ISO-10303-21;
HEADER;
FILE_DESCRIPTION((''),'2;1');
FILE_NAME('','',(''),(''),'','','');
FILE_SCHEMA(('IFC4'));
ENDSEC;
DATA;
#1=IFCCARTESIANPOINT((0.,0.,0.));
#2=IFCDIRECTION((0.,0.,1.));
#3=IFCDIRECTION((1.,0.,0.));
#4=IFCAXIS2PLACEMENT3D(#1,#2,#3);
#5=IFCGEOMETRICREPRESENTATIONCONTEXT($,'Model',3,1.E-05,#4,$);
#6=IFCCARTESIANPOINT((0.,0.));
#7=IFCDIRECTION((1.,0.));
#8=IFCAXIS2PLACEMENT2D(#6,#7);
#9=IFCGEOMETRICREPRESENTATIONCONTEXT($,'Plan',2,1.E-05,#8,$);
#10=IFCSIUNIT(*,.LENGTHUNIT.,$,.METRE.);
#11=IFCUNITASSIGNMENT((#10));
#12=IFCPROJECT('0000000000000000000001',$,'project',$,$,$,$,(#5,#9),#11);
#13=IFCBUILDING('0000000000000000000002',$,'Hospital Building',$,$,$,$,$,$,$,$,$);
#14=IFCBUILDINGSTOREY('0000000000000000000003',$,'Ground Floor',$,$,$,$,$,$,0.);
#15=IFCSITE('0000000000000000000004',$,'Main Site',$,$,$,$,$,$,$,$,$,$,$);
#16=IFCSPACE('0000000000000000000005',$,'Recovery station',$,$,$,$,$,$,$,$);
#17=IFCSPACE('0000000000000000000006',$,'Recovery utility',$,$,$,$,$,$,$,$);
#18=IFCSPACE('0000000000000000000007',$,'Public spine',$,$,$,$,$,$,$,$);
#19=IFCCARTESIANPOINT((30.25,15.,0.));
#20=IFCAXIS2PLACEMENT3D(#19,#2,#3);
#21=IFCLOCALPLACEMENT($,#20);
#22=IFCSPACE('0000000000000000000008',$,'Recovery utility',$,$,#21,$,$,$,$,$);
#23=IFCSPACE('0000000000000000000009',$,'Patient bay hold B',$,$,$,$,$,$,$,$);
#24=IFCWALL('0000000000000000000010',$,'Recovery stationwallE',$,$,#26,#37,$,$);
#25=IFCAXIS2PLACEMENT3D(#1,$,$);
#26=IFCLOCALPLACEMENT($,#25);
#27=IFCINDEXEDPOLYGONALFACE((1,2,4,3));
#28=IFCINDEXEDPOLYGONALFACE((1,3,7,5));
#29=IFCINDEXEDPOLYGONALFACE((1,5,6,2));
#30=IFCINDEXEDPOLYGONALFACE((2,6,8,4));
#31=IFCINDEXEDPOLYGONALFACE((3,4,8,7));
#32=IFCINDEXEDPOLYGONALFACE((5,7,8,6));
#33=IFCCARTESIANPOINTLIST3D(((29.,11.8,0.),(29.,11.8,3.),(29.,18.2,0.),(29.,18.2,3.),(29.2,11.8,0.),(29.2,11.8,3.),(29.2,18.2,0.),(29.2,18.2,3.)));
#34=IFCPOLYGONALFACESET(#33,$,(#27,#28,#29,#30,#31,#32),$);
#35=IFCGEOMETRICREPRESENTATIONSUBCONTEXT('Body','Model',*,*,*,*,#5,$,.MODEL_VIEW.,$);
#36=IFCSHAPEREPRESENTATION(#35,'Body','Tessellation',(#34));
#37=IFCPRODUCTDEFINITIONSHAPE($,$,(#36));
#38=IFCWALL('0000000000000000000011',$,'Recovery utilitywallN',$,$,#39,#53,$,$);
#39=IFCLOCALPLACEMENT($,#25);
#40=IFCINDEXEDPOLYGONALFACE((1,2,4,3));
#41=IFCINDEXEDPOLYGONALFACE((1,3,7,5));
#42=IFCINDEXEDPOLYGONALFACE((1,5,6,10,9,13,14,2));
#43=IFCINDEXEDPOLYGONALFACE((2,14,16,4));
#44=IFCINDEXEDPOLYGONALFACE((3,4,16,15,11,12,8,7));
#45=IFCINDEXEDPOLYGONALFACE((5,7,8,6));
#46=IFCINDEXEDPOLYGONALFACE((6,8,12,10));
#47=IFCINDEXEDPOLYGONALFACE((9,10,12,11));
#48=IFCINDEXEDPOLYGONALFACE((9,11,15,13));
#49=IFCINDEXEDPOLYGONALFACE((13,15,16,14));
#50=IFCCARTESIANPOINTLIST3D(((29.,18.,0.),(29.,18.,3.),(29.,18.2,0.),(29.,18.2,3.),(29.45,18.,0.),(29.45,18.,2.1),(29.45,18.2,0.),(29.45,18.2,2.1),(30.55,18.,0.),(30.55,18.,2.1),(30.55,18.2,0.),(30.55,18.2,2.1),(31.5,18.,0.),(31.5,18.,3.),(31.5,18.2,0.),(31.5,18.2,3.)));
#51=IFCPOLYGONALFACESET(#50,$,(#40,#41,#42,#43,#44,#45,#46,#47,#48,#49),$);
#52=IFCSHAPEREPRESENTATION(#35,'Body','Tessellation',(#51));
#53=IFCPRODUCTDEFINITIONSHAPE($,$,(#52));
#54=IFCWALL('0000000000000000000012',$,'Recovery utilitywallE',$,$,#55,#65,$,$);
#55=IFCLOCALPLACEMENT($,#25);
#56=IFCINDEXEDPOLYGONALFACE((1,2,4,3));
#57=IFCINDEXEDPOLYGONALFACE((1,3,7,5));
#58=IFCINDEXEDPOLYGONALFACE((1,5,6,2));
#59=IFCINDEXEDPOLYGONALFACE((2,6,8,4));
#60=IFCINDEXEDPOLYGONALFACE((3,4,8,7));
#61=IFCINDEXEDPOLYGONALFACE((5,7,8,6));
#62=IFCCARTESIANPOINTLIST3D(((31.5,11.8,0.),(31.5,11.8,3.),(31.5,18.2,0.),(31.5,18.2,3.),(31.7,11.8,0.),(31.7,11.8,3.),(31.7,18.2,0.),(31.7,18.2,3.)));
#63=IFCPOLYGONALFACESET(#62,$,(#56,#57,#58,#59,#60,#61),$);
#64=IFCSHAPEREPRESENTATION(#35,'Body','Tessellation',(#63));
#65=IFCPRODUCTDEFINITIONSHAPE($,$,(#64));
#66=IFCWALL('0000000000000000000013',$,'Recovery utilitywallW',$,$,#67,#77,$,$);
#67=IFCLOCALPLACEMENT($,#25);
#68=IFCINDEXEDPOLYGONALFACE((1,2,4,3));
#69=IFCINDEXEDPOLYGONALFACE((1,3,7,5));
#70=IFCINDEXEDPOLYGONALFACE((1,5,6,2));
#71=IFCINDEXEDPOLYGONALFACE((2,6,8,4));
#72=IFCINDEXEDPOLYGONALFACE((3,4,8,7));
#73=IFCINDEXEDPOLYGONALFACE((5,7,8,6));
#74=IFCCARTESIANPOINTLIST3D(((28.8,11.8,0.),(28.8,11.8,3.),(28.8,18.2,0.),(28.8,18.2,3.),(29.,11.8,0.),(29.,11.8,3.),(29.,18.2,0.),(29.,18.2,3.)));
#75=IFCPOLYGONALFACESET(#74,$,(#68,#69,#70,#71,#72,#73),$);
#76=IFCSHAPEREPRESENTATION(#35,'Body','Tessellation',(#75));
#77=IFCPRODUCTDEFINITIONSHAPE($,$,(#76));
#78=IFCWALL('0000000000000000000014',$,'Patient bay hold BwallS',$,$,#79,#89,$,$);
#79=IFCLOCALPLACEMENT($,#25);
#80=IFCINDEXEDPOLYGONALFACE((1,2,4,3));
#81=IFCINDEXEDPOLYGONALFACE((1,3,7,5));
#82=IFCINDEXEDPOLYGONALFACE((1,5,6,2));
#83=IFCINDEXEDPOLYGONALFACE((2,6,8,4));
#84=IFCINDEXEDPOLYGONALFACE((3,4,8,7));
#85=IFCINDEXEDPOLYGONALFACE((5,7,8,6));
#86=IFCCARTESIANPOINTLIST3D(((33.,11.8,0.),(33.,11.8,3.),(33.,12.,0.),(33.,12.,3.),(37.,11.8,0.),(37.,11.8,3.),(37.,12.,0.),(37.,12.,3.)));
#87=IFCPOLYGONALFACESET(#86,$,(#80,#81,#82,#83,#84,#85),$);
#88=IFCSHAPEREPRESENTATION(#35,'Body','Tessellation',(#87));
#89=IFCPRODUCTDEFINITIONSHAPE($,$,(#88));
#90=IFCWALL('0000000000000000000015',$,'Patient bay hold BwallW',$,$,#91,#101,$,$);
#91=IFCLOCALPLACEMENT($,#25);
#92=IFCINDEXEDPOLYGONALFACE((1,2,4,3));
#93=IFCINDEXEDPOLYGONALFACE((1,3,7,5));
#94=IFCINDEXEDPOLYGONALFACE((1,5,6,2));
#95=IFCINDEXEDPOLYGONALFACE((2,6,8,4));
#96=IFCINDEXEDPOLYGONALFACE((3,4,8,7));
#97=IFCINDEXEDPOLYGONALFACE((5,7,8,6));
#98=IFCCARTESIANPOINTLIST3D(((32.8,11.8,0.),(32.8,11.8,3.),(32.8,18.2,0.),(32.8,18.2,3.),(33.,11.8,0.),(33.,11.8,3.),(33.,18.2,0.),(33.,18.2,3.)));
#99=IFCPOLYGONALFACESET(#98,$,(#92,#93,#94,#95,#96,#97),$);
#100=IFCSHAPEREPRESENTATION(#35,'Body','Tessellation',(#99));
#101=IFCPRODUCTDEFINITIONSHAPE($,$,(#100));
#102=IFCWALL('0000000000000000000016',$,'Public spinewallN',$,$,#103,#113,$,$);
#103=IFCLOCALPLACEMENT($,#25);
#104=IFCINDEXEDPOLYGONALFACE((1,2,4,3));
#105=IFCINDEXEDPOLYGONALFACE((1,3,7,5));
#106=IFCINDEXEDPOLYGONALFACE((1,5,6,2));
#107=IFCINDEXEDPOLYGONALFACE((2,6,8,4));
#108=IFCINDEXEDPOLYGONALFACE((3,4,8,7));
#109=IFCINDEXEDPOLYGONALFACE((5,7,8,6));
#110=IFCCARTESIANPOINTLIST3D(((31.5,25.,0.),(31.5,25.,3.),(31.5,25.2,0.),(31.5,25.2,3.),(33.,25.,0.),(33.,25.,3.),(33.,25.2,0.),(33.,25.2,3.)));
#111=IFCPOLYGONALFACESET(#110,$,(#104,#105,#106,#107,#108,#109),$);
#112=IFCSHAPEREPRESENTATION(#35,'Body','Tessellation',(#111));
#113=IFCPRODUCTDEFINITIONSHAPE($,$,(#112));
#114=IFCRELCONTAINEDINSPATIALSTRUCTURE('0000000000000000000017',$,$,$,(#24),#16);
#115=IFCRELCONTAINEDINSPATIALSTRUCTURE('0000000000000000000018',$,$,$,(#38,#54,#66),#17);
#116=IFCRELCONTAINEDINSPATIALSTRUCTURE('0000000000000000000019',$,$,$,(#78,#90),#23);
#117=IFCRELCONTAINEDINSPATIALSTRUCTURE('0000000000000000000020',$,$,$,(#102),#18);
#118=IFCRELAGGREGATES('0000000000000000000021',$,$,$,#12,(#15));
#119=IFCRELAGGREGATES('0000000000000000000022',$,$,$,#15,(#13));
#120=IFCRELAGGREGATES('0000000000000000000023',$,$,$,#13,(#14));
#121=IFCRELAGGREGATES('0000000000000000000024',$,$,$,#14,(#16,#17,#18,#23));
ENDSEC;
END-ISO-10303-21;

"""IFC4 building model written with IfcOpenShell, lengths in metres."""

from ifc_helpers import new_model, si_unit, frame, origin_with_axes, origin_2d_with_axis, place, context, subcontext, project, spatial, indexed_curve, outline, extrude, element, save


model = new_model("IFC4")

# Units and contexts
model_context = context("Model", 3, precision=1e-05, world=origin_with_axes())
plan_context = context("Plan", 2, precision=1e-05, world=origin_2d_with_axis())
body_context = subcontext(model_context, "Body", "Model", "MODEL_VIEW")
ifc_project = project(units=[si_unit("LENGTHUNIT", "METRE")], contexts=[model_context, plan_context])

# Site, building, storey
site = spatial("IfcSite", under=ifc_project, Name="Main Site")
building = spatial("IfcBuilding", under=site, Name="Hospital Building")
storey = spatial("IfcBuildingStorey", under=building, Name="Ground Floor", Elevation=0.0)

# Shared definitions
space_1 = spatial("IfcSpace", under=storey, Name="Recovery station")

# Shared definitions
space_2 = spatial("IfcSpace", under=storey, Name="Recovery utility")

# Shared definitions
space_3 = spatial("IfcSpace", under=storey, Name="Public spine")

# Walls
wall_1_placement = place(None, frame((29.2, 11.8, 0.0), z_axis=(0.0, 0.0, 1.0), x_axis=(0.0, 1.0, 0.0)))
element("IfcWall", 1, at=wall_1_placement, inside=space_1, Name="Recovery stationwallE", context=body_context, shape_type="SweptSolid", body=[
    extrude(outline(indexed_curve([(0.0, 0.0), (0.0, 0.2), (6.4, 0.2), (6.4, 0.0), (0.0, 0.0)], self_intersect=False)), origin_with_axes(), (0.0, 0.0, 1.0), 3.0),
])
wall_2_placement = place(None, frame((29.0, 18.0, 0.0), z_axis=(0.0, 0.0, 1.0), x_axis=(1.0, 0.0, 0.0)))
wall_2 = element("IfcWall", 2, at=wall_2_placement, inside=space_2, Name="Recovery utilitywallN", context=body_context, shape_type="SweptSolid", body=[
    extrude(outline(indexed_curve([(0.0, 0.0), (0.0, 0.2), (2.5, 0.2), (2.5, 0.0), (0.0, 0.0)], self_intersect=False)), origin_with_axes(), (0.0, 0.0, 1.0), 3.0),
])

# Shared definitions
space_4_placement = place(None, frame((30.25, 15.0, 0.0), z_axis=(0.0, 0.0, 1.0), x_axis=(1.0, 0.0, 0.0)))
space_4 = spatial("IfcSpace", at=space_4_placement, Name="Recovery utility")

# Opening
opening_1_placement = place(wall_2_placement, frame((0.45, -0.1, 0.0), z_axis=(0.0, 0.0, 1.0), x_axis=(1.0, 0.0, 0.0)))
element("IfcOpeningElement", 3, at=opening_1_placement, inside=space_4, cuts=wall_2, context=body_context, shape_type="SweptSolid", body=[
    extrude(outline(indexed_curve([(0.0, 0.0), (0.0, 0.4), (1.1, 0.4), (1.1, 0.0), (0.0, 0.0)], self_intersect=False)), origin_with_axes(), (0.0, 0.0, 1.0), 2.1),
])

# Walls
for number, where, z_axis, x_axis, name in (
    (4, (31.7, 11.8, 0.0), (0.0, 0.0, 1.0), (0.0, 1.0, 0.0), "Recovery utilitywallE"),
    (5, (29.0, 11.8, 0.0), (0.0, 0.0, 1.0), (0.0, 1.0, 0.0), "Recovery utilitywallW"),
):
    element("IfcWall", number, at=place(None, frame(where, z_axis=z_axis, x_axis=x_axis)), inside=space_2, Name=name, context=body_context, shape_type="SweptSolid", body=[
        extrude(outline(indexed_curve([(0.0, 0.0), (0.0, 0.2), (6.4, 0.2), (6.4, 0.0), (0.0, 0.0)], self_intersect=False)), origin_with_axes(), (0.0, 0.0, 1.0), 3.0),
    ])

# Shared definitions
space_5 = spatial("IfcSpace", under=storey, Name="Patient bay hold B")

# Walls
wall_3_placement = place(None, frame((33.0, 11.8, 0.0), z_axis=(0.0, 0.0, 1.0), x_axis=(1.0, 0.0, 0.0)))
element("IfcWall", 6, at=wall_3_placement, inside=space_5, Name="Patient bay hold BwallS", context=body_context, shape_type="SweptSolid", body=[
    extrude(outline(indexed_curve([(0.0, 0.0), (0.0, 0.2), (4.0, 0.2), (4.0, 0.0), (0.0, 0.0)], self_intersect=False)), origin_with_axes(), (0.0, 0.0, 1.0), 3.0),
])
wall_4_placement = place(None, frame((33.0, 11.8, 0.0), z_axis=(0.0, 0.0, 1.0), x_axis=(0.0, 1.0, 0.0)))
element("IfcWall", 7, at=wall_4_placement, inside=space_5, Name="Patient bay hold BwallW", context=body_context, shape_type="SweptSolid", body=[
    extrude(outline(indexed_curve([(0.0, 0.0), (0.0, 0.2), (6.4, 0.2), (6.4, 0.0), (0.0, 0.0)], self_intersect=False)), origin_with_axes(), (0.0, 0.0, 1.0), 3.0),
])
wall_5_placement = place(None, frame((31.5, 25.0, 0.0), z_axis=(0.0, 0.0, 1.0), x_axis=(1.0, 0.0, 0.0)))
element("IfcWall", 8, at=wall_5_placement, inside=space_3, Name="Public spinewallN", context=body_context, shape_type="SweptSolid", body=[
    extrude(outline(indexed_curve([(0.0, 0.0), (0.0, 0.2), (1.5, 0.2), (1.5, 0.0), (0.0, 0.0)], self_intersect=False)), origin_with_axes(), (0.0, 0.0, 1.0), 3.0),
])

save(model, "model.ifc")
